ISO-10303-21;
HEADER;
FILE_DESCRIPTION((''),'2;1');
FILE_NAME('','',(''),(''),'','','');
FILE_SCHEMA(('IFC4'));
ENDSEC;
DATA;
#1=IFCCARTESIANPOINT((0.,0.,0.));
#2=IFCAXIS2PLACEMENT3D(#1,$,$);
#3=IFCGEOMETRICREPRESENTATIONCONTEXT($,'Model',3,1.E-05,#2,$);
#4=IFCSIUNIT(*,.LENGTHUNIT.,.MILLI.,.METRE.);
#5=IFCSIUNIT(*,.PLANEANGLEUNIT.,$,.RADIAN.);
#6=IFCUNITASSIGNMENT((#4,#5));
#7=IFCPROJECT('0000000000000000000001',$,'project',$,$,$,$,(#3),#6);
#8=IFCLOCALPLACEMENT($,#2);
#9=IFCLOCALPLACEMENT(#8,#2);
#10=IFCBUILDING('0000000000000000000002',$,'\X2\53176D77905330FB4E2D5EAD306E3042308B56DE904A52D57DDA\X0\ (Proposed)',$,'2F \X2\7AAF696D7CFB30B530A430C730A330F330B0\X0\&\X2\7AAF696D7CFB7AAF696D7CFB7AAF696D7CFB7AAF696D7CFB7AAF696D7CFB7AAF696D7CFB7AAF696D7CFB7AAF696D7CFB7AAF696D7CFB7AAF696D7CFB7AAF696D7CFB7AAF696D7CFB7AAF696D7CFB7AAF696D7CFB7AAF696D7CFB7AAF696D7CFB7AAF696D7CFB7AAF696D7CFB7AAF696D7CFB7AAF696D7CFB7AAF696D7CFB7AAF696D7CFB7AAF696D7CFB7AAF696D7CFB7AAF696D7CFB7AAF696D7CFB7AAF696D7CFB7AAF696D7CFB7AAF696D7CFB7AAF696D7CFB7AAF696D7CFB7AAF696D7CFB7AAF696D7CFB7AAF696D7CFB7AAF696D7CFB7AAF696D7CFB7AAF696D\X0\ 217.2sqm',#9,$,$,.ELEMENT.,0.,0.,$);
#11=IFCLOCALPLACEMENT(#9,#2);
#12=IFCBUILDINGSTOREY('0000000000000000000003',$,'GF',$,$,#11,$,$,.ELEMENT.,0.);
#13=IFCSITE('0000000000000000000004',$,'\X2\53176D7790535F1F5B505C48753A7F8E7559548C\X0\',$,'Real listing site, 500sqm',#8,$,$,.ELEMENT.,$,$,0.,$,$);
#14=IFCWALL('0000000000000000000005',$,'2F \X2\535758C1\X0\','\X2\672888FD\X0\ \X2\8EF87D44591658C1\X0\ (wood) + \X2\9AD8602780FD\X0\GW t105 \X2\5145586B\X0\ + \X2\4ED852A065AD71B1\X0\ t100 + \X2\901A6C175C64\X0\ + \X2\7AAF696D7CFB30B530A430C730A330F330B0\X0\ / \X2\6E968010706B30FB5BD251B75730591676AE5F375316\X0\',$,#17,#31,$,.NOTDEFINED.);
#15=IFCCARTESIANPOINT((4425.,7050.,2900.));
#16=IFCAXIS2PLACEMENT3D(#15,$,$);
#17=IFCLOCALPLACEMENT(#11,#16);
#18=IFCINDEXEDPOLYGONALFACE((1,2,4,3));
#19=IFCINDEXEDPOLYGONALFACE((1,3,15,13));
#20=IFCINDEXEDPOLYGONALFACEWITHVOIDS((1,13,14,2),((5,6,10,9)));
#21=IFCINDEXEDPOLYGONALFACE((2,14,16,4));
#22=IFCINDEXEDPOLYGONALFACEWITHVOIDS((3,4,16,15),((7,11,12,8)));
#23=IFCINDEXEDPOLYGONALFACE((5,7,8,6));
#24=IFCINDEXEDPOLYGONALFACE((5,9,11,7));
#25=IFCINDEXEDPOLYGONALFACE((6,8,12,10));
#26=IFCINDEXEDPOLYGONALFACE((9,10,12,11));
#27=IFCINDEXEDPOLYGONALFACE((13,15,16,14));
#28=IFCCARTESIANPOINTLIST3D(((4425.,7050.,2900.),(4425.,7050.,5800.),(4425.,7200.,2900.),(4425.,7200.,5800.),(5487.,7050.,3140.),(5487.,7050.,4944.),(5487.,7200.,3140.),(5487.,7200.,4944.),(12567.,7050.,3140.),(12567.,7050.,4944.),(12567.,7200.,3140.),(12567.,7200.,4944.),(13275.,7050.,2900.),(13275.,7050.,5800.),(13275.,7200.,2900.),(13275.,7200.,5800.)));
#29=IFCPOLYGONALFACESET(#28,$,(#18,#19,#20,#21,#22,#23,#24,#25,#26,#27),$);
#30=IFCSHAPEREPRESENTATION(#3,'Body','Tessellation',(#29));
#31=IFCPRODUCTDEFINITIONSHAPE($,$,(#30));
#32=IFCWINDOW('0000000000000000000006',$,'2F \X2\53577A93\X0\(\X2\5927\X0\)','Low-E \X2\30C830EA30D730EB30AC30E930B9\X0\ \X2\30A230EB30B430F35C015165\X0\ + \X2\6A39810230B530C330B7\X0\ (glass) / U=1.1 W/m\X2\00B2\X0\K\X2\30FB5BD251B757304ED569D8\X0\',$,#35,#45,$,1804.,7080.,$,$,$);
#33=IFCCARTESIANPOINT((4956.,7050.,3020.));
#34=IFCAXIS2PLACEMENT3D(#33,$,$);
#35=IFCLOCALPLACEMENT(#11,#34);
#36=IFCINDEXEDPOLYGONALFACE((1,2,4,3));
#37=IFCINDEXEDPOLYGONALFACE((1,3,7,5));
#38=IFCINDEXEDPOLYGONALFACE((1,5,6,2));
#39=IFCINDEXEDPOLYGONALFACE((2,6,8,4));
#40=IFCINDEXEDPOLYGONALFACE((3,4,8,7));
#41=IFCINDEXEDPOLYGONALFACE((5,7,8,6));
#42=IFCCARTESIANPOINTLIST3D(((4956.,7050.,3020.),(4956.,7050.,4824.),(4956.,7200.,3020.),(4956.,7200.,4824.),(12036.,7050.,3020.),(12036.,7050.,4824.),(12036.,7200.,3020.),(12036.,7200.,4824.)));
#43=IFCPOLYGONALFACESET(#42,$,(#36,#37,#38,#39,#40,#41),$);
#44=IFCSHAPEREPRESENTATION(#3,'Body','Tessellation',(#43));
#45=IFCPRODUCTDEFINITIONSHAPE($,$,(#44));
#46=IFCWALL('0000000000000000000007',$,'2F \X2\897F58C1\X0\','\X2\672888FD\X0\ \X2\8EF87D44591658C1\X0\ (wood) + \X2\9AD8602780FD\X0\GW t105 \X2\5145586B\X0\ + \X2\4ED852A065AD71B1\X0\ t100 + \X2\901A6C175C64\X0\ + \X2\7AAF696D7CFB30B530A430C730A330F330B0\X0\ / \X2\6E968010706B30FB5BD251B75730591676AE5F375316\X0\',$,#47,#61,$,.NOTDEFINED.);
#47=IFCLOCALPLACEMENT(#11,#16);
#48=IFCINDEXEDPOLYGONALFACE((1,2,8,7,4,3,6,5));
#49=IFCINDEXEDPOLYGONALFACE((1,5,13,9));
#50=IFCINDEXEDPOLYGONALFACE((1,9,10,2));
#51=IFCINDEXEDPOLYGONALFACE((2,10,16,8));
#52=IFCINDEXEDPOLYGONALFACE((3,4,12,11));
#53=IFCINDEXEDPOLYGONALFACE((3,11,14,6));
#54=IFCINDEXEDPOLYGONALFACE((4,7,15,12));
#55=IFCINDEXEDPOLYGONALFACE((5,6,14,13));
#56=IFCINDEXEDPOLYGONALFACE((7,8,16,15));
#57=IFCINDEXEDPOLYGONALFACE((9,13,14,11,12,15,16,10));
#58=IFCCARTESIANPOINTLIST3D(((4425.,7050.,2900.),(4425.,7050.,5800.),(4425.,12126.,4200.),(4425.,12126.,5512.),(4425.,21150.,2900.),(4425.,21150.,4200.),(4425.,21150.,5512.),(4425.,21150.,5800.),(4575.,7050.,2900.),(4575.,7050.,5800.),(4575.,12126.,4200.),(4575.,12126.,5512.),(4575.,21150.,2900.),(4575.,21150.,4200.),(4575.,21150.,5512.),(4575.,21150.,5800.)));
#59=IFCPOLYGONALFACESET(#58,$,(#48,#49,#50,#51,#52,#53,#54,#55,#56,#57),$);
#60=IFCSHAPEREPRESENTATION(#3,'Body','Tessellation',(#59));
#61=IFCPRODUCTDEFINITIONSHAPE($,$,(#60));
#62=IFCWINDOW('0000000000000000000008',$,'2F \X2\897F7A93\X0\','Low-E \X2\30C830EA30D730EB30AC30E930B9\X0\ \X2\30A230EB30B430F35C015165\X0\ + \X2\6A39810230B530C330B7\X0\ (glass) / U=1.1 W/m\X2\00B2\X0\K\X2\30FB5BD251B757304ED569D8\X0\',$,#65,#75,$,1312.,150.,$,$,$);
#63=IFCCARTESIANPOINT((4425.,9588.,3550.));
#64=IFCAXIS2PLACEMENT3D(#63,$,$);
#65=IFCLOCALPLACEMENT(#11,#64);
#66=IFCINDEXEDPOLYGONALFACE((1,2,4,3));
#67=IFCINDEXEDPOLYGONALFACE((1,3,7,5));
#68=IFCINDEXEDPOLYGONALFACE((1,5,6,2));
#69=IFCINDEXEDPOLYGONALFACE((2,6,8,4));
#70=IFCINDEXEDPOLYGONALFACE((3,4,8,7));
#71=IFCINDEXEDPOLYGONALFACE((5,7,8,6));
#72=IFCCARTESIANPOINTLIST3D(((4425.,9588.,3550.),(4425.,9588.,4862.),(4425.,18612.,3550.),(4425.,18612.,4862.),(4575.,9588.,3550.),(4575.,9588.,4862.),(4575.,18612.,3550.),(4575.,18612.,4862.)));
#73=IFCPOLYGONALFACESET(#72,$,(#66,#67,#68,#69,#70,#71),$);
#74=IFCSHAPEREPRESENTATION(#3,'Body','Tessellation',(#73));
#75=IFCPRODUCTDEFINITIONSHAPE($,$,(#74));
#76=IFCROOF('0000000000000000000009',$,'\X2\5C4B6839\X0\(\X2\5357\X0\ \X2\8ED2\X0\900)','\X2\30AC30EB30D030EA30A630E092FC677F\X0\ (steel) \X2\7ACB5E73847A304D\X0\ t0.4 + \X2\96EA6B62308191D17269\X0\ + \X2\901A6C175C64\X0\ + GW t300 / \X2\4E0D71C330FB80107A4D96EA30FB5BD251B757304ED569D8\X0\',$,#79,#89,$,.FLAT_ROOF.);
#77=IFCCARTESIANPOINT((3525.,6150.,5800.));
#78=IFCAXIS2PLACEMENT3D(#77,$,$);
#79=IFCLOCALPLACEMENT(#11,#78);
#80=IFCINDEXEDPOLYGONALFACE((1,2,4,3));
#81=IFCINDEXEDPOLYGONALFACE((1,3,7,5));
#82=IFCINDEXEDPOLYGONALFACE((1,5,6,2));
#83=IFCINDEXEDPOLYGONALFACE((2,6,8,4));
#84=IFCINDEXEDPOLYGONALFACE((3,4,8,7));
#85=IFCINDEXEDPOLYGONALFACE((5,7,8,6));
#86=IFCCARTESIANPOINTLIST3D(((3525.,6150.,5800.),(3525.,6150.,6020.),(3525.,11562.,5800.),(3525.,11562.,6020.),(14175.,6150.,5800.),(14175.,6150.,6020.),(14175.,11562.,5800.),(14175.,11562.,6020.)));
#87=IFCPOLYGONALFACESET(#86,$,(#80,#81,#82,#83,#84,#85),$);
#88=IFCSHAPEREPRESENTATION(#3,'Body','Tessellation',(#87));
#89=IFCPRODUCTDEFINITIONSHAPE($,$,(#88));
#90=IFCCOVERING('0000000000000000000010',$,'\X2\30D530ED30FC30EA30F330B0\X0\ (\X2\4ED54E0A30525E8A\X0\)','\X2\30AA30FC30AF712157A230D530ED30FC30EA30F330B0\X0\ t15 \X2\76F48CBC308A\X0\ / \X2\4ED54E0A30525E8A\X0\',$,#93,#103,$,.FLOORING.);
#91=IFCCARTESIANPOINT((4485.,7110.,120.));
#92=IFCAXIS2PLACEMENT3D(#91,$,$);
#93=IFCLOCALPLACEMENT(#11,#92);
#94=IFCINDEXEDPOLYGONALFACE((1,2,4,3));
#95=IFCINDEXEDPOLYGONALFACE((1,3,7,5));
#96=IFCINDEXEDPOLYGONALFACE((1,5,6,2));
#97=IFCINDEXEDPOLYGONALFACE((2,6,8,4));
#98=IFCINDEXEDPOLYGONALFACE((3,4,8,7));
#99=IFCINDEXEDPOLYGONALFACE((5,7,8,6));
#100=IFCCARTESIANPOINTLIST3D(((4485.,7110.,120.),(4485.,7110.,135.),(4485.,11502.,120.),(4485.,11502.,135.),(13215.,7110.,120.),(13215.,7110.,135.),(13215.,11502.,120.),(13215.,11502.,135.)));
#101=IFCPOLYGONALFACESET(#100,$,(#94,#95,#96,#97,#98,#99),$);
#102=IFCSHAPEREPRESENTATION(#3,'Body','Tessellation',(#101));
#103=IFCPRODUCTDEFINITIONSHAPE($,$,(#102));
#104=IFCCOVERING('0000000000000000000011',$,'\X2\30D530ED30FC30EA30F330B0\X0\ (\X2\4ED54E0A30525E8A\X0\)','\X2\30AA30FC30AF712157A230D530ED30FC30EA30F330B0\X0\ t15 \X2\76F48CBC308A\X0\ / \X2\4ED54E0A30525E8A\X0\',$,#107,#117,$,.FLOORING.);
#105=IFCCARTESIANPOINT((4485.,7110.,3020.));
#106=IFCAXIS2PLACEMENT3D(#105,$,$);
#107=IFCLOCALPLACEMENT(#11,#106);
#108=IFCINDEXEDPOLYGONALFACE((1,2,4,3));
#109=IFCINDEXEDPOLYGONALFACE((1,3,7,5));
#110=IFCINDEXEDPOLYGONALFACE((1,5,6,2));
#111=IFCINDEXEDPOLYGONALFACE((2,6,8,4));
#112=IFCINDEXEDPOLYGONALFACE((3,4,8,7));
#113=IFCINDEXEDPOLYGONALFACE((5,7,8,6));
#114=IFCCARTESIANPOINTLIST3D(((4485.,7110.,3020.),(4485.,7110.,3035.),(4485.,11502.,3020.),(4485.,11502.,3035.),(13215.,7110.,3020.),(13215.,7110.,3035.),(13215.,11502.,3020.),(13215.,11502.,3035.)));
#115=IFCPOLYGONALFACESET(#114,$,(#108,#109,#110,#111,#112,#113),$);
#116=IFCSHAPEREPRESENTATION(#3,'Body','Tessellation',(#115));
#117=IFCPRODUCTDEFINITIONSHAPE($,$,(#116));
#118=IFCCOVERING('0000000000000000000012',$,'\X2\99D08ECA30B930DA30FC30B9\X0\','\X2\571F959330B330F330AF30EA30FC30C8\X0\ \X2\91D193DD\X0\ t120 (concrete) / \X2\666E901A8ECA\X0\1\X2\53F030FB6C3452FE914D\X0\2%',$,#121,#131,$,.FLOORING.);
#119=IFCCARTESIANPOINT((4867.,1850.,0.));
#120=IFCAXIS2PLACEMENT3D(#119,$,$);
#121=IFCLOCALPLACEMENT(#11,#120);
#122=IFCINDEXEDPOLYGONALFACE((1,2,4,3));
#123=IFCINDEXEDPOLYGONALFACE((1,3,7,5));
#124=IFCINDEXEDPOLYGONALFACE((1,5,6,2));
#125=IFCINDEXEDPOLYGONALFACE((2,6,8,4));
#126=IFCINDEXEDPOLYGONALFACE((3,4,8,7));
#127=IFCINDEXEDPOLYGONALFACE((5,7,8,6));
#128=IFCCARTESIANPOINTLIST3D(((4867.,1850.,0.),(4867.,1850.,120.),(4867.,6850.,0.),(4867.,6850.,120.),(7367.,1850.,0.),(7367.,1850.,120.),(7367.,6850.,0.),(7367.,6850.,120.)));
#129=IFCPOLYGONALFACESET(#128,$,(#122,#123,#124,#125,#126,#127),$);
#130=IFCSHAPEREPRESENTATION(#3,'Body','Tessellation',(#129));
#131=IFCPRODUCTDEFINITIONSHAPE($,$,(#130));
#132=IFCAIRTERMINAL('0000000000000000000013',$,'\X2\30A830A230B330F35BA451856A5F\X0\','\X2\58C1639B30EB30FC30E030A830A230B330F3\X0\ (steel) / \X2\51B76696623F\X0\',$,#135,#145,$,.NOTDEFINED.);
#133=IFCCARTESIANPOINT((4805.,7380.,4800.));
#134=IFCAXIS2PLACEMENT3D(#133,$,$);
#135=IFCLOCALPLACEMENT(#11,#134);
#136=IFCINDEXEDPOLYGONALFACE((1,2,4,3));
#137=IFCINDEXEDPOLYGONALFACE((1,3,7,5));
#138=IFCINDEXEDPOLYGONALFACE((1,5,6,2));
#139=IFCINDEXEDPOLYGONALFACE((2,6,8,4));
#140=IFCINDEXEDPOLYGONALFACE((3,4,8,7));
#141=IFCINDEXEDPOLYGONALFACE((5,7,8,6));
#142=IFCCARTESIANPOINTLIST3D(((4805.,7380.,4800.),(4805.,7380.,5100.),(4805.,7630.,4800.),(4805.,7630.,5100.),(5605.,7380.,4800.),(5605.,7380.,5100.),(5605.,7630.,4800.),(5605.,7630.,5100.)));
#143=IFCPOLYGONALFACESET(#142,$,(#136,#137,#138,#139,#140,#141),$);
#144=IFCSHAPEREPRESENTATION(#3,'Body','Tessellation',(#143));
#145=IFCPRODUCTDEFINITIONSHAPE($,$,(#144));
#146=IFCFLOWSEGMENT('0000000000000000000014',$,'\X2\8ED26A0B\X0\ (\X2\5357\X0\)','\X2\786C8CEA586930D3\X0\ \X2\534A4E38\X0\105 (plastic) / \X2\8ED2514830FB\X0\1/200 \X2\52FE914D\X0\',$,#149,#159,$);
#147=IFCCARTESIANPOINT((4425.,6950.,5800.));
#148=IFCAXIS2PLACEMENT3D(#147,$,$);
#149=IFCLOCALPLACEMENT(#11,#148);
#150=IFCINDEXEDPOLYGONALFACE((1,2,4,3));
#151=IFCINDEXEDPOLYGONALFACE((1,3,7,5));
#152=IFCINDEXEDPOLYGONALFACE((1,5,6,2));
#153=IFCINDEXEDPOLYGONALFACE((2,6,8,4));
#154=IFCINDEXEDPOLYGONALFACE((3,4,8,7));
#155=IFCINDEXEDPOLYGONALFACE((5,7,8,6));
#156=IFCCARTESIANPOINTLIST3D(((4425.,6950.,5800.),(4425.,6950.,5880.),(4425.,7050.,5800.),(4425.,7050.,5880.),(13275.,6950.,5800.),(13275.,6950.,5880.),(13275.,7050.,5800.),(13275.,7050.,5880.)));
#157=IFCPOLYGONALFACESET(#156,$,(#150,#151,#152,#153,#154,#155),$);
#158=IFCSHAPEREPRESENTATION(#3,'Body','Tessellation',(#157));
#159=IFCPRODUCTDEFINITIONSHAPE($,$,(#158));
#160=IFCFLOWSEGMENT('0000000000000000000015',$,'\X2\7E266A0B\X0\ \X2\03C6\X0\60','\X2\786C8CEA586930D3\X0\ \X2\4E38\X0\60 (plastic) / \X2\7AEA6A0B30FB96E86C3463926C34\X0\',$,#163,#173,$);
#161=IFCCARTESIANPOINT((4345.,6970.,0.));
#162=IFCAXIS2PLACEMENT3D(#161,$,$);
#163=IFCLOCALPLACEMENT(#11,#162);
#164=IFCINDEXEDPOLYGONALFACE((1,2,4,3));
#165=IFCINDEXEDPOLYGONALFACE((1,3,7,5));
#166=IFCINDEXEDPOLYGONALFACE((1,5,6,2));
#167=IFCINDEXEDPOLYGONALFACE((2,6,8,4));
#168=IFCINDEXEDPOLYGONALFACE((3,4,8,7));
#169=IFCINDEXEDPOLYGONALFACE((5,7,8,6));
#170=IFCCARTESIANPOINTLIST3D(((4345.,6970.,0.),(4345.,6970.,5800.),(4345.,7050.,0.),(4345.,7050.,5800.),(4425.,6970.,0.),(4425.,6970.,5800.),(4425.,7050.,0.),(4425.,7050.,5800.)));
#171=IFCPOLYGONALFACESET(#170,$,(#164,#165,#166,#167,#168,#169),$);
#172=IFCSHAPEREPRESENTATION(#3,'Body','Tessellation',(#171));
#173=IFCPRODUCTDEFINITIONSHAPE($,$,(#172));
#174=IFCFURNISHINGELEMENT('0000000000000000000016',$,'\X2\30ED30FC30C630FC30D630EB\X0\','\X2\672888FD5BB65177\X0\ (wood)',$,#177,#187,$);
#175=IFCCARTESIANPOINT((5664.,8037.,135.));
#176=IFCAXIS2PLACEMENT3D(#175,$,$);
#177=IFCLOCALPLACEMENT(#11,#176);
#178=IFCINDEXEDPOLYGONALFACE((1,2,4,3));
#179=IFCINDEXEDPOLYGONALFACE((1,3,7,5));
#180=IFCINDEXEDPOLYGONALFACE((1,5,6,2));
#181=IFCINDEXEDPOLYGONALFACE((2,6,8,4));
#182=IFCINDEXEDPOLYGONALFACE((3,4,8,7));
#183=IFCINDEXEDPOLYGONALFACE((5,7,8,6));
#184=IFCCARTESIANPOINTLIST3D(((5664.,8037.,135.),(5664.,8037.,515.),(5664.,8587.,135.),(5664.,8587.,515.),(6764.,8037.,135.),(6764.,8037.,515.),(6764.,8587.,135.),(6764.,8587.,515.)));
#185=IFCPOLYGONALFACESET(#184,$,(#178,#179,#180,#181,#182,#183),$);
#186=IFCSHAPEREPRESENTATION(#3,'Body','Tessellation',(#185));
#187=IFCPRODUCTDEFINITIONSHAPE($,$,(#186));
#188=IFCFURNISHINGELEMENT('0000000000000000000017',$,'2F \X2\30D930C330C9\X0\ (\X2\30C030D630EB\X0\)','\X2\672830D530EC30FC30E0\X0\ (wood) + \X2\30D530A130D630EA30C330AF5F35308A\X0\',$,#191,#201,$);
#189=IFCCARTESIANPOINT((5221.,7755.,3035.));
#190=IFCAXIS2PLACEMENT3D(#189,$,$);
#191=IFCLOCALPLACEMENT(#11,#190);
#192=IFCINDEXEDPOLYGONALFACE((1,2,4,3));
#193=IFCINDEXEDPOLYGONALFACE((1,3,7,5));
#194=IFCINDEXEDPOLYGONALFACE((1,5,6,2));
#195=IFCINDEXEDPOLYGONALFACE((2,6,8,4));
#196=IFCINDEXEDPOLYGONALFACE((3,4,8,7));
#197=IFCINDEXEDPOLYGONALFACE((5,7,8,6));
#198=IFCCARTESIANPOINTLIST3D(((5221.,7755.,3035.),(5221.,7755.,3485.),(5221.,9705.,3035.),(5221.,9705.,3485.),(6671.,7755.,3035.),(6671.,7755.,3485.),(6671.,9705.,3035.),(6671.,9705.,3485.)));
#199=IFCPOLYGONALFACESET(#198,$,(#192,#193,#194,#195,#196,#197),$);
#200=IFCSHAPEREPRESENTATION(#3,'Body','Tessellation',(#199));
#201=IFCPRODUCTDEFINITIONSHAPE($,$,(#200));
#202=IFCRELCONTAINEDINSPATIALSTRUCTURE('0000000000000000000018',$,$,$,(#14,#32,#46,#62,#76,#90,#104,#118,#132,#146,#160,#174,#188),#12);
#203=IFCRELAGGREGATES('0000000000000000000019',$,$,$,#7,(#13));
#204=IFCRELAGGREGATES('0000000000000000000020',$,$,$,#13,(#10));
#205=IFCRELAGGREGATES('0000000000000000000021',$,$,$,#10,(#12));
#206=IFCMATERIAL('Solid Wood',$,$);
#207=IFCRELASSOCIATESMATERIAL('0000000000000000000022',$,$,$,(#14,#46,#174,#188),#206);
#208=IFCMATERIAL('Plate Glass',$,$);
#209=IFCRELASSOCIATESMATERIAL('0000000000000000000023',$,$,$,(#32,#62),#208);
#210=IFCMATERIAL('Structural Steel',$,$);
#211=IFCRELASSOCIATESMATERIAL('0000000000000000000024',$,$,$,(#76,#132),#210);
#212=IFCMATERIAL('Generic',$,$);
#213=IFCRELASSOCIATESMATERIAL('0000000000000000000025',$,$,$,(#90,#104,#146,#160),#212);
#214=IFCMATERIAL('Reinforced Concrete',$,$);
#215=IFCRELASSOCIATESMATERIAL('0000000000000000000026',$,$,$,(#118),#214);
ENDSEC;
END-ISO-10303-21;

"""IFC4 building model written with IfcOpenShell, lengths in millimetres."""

from ifc_helpers import new_model, si_unit, frame, frame_2d, origin, place, context, project, spatial, rectangle, extrude, material, element, fill, save


model = new_model("IFC4")

# Units and contexts
model_context = context("Model", 3, precision=1e-05, world=origin())
ifc_project = project(units=[si_unit("LENGTHUNIT", "METRE", prefix="MILLI"), si_unit("PLANEANGLEUNIT", "RADIAN")], contexts=[model_context])

# Site, building, storey
site_placement = place(None, origin())
site = spatial("IfcSite", under=ifc_project, at=site_placement, Name="北海道弟子屈町美留和", ObjectType="Real listing site, 500sqm", CompositionType="ELEMENT", RefElevation=0.0)
building_placement = place(site_placement, origin())
building = spatial("IfcBuilding", under=site, at=building_placement, Name="北海道・中庭のある回遊動線 (Proposed)", ObjectType="2F 窯業系サイディング&窯業系窯業系窯業系窯業系窯業系窯業系窯業系窯業系窯業系窯業系窯業系窯業系窯業系窯業系窯業系窯業系窯業系窯業系窯業系窯業系窯業系窯業系窯業系窯業系窯業系窯業系窯業系窯業系窯業系窯業系窯業系窯業系窯業系窯業系窯業系窯業系窯業 217.2sqm", CompositionType="ELEMENT", ElevationOfRefHeight=0.0, ElevationOfTerrain=0.0)
storey_placement = place(building_placement, origin())
storey = spatial("IfcBuildingStorey", under=building, at=storey_placement, Name="GF", CompositionType="ELEMENT", Elevation=0.0)

# Shared definitions
ifc_material_1 = material(Name="Solid Wood")

# Shared definitions
ifc_material_2 = material(Name="Reinforced Concrete")

# Shared definitions
ifc_material_3 = material(Name="Plate Glass")

# Walls, openings, windows
wall_1_placement = place(storey_placement, frame((4425.0, 7050.0, 2900.0)))
wall_1 = element("IfcWall", 1, at=wall_1_placement, inside=storey, material=ifc_material_1, Name="2F 南壁", Description="木製 軸組外壁 (wood) + 高性能GW t105 充填 + 付加断熱 t100 + 通気層 + 窯業系サイディング / 準耐火・寒冷地外皮強化", PredefinedType="NOTDEFINED", context=model_context, shape_type="SweptSolid", body=[
    extrude(rectangle(XDim=8850.0, YDim=150.0, at=frame_2d((4425.0, 75.0))), frame((4425.0, 7050.0, 2900.0)), (0.0, 0.0, 1.0), 2900.0),
])
opening_1_placement = place(storey_placement, frame((4956.0, 7050.0, 3020.0)))
opening_1 = element("IfcOpeningElement", 2, at=opening_1_placement, cuts=wall_1, PredefinedType="NOTDEFINED", context=model_context, shape_type="SweptSolid", body=[
    extrude(rectangle(XDim=7080.0, YDim=150.0, at=frame_2d((3540.0, 75.0))), frame((4956.0, 7050.0, 3020.0)), (0.0, 0.0, 1.0), 1804.0),
])
window_1_placement = place(storey_placement, frame((4956.0, 7050.0, 3020.0)))
window_1 = element("IfcWindow", 3, at=window_1_placement, inside=storey, material=ifc_material_3, Name="2F 南窓(大)", Description="Low-E トリプルガラス アルゴン封入 + 樹脂サッシ (glass) / U=1.1 W/m²K・寒冷地仕様", OverallHeight=1804.0, OverallWidth=7080.0, context=model_context, shape_type="SweptSolid", body=[
    extrude(rectangle(XDim=7080.0, YDim=150.0, at=frame_2d((3540.0, 75.0))), frame((4956.0, 7050.0, 3020.0)), (0.0, 0.0, 1.0), 1804.0),
])
fill(opening_1, window_1)
wall_2_placement = place(storey_placement, frame((4425.0, 7050.0, 2900.0)))
wall_2 = element("IfcWall", 4, at=wall_2_placement, inside=storey, material=ifc_material_1, Name="2F 西壁", Description="木製 軸組外壁 (wood) + 高性能GW t105 充填 + 付加断熱 t100 + 通気層 + 窯業系サイディング / 準耐火・寒冷地外皮強化", PredefinedType="NOTDEFINED", context=model_context, shape_type="SweptSolid", body=[
    extrude(rectangle(XDim=150.0, YDim=14100.0, at=frame_2d((75.0, 7050.0))), frame((4425.0, 7050.0, 2900.0)), (0.0, 0.0, 1.0), 2900.0),
])
opening_2_placement = place(storey_placement, frame((4425.0, 9588.0, 3550.0)))
opening_2 = element("IfcOpeningElement", 5, at=opening_2_placement, cuts=wall_2, PredefinedType="NOTDEFINED", context=model_context, shape_type="SweptSolid", body=[
    extrude(rectangle(XDim=150.0, YDim=9024.0, at=frame_2d((75.0, 4512.0))), frame((4425.0, 9588.0, 3550.0)), (0.0, 0.0, 1.0), 1312.0),
])
window_2_placement = place(storey_placement, frame((4425.0, 9588.0, 3550.0)))
window_2 = element("IfcWindow", 6, at=window_2_placement, inside=storey, material=ifc_material_3, Name="2F 西窓", Description="Low-E トリプルガラス アルゴン封入 + 樹脂サッシ (glass) / U=1.1 W/m²K・寒冷地仕様", OverallHeight=1312.0, OverallWidth=150.0, context=model_context, shape_type="SweptSolid", body=[
    extrude(rectangle(XDim=150.0, YDim=9024.0, at=frame_2d((75.0, 4512.0))), frame((4425.0, 9588.0, 3550.0)), (0.0, 0.0, 1.0), 1312.0),
])
fill(opening_2, window_2)

# Roof
ifc_material_4 = material(Name="Structural Steel")
for number, where, name in (
    (7, (3525.0, 6150.0, 5800.0), "屋根(南 軒900)"),
):
    element("IfcRoof", number, at=place(storey_placement, frame(where)), inside=storey, material=ifc_material_4, Name=name, Description="ガルバリウム鋼板 (steel) 立平葺き t0.4 + 雪止め金物 + 通気層 + GW t300 / 不燃・耐積雪・寒冷地仕様", PredefinedType="FLAT_ROOF", context=model_context, shape_type="SweptSolid", body=[
        extrude(rectangle(XDim=10650.0, YDim=5412.0, at=frame_2d((5325.0, 2706.0))), frame((3525.0, 6150.0, 5800.0)), (0.0, 0.0, 1.0), 220.0),
    ])

# Coverings
ifc_material_5 = material(Name="Generic")
covering_1_placement = place(storey_placement, frame((4485.0, 7110.0, 120.0)))
element("IfcCovering", 8, at=covering_1_placement, inside=storey, material=ifc_material_5, Name="フローリング (仕上げ床)", Description="オーク無垢フローリング t15 直貼り / 仕上げ床", PredefinedType="FLOORING", context=model_context, shape_type="SweptSolid", body=[
    extrude(rectangle(XDim=8730.0, YDim=4392.0, at=frame_2d((4365.0, 2196.0))), frame((4485.0, 7110.0, 120.0)), (0.0, 0.0, 1.0), 15.0),
])
covering_2_placement = place(storey_placement, frame((4485.0, 7110.0, 3020.0)))
element("IfcCovering", 9, at=covering_2_placement, inside=storey, material=ifc_material_5, Name="フローリング (仕上げ床)", Description="オーク無垢フローリング t15 直貼り / 仕上げ床", PredefinedType="FLOORING", context=model_context, shape_type="SweptSolid", body=[
    extrude(rectangle(XDim=8730.0, YDim=4392.0, at=frame_2d((4365.0, 2196.0))), frame((4485.0, 7110.0, 3020.0)), (0.0, 0.0, 1.0), 15.0),
])
covering_3_placement = place(storey_placement, frame((4867.0, 1850.0, 0.0)))
element("IfcCovering", 10, at=covering_3_placement, inside=storey, material=ifc_material_2, Name="駐車スペース", Description="土間コンクリート 金鏝 t120 (concrete) / 普通車1台・水勾配2%", PredefinedType="FLOORING", context=model_context, shape_type="SweptSolid", body=[
    extrude(rectangle(XDim=2500.0, YDim=5000.0, at=frame_2d((1250.0, 2500.0))), frame((4867.0, 1850.0, 0.0)), (0.0, 0.0, 1.0), 120.0),
])

# Air terminal
air_terminal_placement = place(storey_placement, frame((4805.0, 7380.0, 4800.0)))
element("IfcAirTerminal", 11, at=air_terminal_placement, inside=storey, material=ifc_material_4, Name="エアコン室内機", Description="壁掛ルームエアコン (steel) / 冷暖房", PredefinedType="NOTDEFINED", context=model_context, shape_type="SweptSolid", body=[
    extrude(rectangle(XDim=800.0, YDim=250.0, at=frame_2d((400.0, 125.0))), frame((4805.0, 7380.0, 4800.0)), (0.0, 0.0, 1.0), 300.0),
])

# Flow segments
flow_segment_1_placement = place(storey_placement, frame((4425.0, 6950.0, 5800.0)))
element("IfcFlowSegment", 12, at=flow_segment_1_placement, inside=storey, material=ifc_material_5, Name="軒樋 (南)", Description="硬質塩ビ 半丸105 (plastic) / 軒先・1/200 勾配", context=model_context, shape_type="SweptSolid", body=[
    extrude(rectangle(XDim=8850.0, YDim=100.0, at=frame_2d((4425.0, 50.0))), frame((4425.0, 6950.0, 5800.0)), (0.0, 0.0, 1.0), 80.0),
])
flow_segment_2_placement = place(storey_placement, frame((4345.0, 6970.0, 0.0)))
element("IfcFlowSegment", 13, at=flow_segment_2_placement, inside=storey, material=ifc_material_5, Name="縦樋 φ60", Description="硬質塩ビ 丸60 (plastic) / 竪樋・雨水排水", context=model_context, shape_type="SweptSolid", body=[
    extrude(rectangle(XDim=80.0, YDim=80.0, at=frame_2d((40.0, 40.0))), frame((4345.0, 6970.0, 0.0)), (0.0, 0.0, 1.0), 5800.0),
])

# Furnishing elements
furnishing_1_placement = place(storey_placement, frame((5664.0, 8037.0, 135.0)))
element("IfcFurnishingElement", 14, at=furnishing_1_placement, inside=storey, material=ifc_material_1, Name="ローテーブル", Description="木製家具 (wood)", context=model_context, shape_type="SweptSolid", body=[
    extrude(rectangle(XDim=1100.0, YDim=550.0, at=frame_2d((550.0, 275.0))), frame((5664.0, 8037.0, 135.0)), (0.0, 0.0, 1.0), 380.0),
])
furnishing_2_placement = place(storey_placement, frame((5221.0, 7755.0, 3035.0)))
element("IfcFurnishingElement", 15, at=furnishing_2_placement, inside=storey, material=ifc_material_1, Name="2F ベッド (ダブル)", Description="木フレーム (wood) + ファブリック張り", context=model_context, shape_type="SweptSolid", body=[
    extrude(rectangle(XDim=1450.0, YDim=1950.0, at=frame_2d((725.0, 975.0))), frame((5221.0, 7755.0, 3035.0)), (0.0, 0.0, 1.0), 450.0),
])

save(model, "model.ifc")
